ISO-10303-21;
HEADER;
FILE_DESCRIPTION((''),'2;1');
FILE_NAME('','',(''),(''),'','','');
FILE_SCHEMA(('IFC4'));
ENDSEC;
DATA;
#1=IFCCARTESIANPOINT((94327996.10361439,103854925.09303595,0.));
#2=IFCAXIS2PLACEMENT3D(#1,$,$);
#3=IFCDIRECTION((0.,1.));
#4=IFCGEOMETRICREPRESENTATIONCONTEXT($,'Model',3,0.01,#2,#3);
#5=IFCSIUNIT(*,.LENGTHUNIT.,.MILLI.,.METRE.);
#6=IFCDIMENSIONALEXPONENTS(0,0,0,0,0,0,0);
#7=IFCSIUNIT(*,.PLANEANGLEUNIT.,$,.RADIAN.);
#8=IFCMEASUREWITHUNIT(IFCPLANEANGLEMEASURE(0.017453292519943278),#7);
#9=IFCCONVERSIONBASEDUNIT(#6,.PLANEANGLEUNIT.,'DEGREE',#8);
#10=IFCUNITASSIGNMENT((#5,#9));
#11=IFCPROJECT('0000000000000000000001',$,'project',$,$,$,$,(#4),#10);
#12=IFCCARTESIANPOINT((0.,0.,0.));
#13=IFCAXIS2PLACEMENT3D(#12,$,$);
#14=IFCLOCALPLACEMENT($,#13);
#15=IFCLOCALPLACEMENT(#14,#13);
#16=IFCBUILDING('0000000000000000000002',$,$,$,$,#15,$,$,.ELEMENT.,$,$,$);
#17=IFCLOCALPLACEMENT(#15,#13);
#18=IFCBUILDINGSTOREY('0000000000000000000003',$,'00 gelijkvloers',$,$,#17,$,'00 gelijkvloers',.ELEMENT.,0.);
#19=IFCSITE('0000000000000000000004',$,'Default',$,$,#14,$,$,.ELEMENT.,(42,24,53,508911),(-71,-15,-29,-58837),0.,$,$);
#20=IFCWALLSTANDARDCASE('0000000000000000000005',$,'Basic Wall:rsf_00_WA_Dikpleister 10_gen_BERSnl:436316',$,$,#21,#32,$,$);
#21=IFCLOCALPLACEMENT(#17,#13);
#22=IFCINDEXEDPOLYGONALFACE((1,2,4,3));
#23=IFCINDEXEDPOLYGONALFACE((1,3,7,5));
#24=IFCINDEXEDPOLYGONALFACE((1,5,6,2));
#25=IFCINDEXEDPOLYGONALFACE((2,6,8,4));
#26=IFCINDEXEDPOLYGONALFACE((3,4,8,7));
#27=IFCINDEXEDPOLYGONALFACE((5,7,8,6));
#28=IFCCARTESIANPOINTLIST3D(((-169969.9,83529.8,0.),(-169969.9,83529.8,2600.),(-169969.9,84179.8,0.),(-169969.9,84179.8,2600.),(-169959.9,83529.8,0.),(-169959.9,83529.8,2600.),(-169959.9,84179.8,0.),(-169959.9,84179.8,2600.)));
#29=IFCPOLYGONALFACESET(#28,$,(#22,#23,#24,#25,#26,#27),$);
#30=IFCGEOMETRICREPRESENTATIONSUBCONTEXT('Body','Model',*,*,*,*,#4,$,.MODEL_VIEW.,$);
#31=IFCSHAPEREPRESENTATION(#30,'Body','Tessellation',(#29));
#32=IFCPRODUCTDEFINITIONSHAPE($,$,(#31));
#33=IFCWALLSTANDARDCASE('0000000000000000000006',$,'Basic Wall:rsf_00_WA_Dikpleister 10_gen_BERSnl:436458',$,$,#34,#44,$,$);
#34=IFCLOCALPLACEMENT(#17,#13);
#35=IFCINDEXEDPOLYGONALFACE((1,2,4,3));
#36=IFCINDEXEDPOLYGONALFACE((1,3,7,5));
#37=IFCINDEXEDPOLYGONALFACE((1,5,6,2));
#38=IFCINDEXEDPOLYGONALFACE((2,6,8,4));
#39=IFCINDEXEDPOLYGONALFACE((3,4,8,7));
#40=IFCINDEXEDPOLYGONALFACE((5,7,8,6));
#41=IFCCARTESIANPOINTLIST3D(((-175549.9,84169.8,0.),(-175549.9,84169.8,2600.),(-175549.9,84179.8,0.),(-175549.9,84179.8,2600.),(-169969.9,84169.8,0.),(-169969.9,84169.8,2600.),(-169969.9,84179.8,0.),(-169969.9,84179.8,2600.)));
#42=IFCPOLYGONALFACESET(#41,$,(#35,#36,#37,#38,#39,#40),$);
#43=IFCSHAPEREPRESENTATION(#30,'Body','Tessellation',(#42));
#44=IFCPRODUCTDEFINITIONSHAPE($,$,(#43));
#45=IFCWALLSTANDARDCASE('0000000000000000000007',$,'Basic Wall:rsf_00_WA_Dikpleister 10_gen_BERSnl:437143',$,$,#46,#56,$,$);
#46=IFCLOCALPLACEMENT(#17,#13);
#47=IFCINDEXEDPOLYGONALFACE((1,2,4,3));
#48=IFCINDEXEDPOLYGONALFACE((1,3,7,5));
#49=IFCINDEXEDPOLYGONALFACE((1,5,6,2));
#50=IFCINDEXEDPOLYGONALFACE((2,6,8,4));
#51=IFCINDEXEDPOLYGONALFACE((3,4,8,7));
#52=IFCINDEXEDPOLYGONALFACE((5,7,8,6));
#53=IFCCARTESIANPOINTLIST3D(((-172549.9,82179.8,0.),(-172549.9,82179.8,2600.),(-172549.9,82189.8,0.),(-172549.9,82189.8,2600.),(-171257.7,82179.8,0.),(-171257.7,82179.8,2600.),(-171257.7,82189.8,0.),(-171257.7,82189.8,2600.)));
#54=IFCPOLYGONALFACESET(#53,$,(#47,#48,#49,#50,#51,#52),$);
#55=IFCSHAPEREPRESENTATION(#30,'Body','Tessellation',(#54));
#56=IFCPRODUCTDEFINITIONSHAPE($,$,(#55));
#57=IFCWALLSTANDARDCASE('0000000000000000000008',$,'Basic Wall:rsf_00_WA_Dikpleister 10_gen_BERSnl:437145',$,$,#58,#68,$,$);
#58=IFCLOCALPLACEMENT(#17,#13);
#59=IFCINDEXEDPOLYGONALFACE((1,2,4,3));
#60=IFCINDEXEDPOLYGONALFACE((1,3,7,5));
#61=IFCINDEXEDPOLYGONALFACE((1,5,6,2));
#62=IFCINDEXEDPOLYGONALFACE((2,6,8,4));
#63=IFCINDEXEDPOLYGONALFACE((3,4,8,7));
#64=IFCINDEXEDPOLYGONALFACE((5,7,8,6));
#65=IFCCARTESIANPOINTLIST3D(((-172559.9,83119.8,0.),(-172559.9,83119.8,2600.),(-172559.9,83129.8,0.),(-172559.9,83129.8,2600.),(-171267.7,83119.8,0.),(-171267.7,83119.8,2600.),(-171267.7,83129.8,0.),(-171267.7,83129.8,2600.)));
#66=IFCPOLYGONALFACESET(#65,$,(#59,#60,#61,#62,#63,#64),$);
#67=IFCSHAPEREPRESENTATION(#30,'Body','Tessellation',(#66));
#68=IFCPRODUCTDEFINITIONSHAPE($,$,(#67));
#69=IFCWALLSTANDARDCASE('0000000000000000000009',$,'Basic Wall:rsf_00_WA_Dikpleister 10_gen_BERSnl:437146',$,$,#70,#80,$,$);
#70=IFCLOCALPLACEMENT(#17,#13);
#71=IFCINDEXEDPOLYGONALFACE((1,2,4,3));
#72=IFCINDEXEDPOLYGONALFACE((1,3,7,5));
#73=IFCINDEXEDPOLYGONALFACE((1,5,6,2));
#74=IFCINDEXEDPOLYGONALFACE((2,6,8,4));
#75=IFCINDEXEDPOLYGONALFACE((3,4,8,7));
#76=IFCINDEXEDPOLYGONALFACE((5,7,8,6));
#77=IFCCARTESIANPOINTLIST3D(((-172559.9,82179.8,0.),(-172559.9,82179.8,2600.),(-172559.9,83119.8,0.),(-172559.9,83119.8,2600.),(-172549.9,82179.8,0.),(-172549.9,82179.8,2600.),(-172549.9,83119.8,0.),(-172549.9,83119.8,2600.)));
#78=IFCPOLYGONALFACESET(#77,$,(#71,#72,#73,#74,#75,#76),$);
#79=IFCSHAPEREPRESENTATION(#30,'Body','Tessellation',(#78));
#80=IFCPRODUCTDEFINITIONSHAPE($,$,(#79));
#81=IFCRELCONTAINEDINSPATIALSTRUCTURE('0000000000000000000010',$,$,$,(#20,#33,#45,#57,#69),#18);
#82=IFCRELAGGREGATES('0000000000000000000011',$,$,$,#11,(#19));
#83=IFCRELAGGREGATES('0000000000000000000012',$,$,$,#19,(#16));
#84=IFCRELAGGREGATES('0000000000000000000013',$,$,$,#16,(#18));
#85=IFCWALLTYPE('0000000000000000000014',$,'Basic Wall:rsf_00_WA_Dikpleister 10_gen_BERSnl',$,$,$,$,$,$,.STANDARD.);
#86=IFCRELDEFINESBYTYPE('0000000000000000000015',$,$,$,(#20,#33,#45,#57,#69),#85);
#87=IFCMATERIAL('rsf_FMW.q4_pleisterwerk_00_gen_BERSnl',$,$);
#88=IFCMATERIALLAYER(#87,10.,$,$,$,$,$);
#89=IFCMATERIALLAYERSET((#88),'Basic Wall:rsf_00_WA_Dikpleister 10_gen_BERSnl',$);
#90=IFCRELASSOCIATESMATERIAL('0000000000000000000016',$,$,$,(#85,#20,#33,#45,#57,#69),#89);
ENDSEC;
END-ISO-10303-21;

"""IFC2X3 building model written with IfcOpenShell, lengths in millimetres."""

from ifc_helpers import new_model, entity, si_unit, converted_unit, direction, frame, frame_2d, origin, place, context, subcontext, project, spatial, rectangle, extrude, material, layer, layer_set, layer_usage, type_object, element, save


model = new_model("IFC2X3")

# Units and contexts
model_context = context("Model", 3, precision=0.01, world=frame((94327996.10361439, 103854925.09303595, 0.0)), true_north=direction((0.0, 1.0)))
body_context = subcontext(model_context, "Body", "Model", "MODEL_VIEW")
ifc_project = project(units=[si_unit("LENGTHUNIT", "METRE", prefix="MILLI"), converted_unit("PLANEANGLEUNIT", "DEGREE", entity("IfcPlaneAngleMeasure", 0.017453292519943278), si_unit("PLANEANGLEUNIT", "RADIAN"), dimensions=[0, 0, 0, 0, 0, 0, 0])], contexts=[model_context])

# Site, building, storey
site_placement = place(None, origin())
site = spatial("IfcSite", under=ifc_project, at=site_placement, Name="Default", CompositionType="ELEMENT", RefLatitude=(42, 24, 53, 508911), RefLongitude=(-71, -15, -29, -58837), RefElevation=0.0)
building_placement = place(site_placement, origin())
building = spatial("IfcBuilding", under=site, at=building_placement, CompositionType="ELEMENT")
storey_placement = place(building_placement, origin())
storey = spatial("IfcBuildingStorey", under=building, at=storey_placement, Name="00 gelijkvloers", LongName="00 gelijkvloers", CompositionType="ELEMENT", Elevation=0.0)

# Shared definitions
ifc_material_1 = material(Name="rsf_FMW.q4_pleisterwerk_00_gen_BERSnl")

# Walls
ifc_layer_1 = layer(ifc_material_1, 10.0)
ifc_layer_set_1 = layer_set([ifc_layer_1], Name="Basic Wall:rsf_00_WA_Dikpleister 10_gen_BERSnl")
wall_type_1 = type_object("IfcWallType", Name="Basic Wall:rsf_00_WA_Dikpleister 10_gen_BERSnl", PredefinedType="STANDARD", material=ifc_layer_set_1)
ifc_layer_usage_1 = layer_usage(ifc_layer_set_1, "AXIS2", "NEGATIVE", 5.0)
wall_1_placement = place(storey_placement, frame((-169964.9, 83529.8, 0.0), z_axis=(0.0, 0.0, 1.0), x_axis=(0.0, 1.0, 0.0)))
element("IfcWallStandardCase", 1, at=wall_1_placement, inside=storey, type_object=wall_type_1, material=ifc_layer_usage_1, Name="Basic Wall:rsf_00_WA_Dikpleister 10_gen_BERSnl:436316", context=body_context, shape_type="SweptSolid", body=[
    extrude(rectangle(XDim=650.0, YDim=10.0, at=frame_2d((325.0, 0.0), x_axis=(-1.0, 0.0))), origin(), (0.0, 0.0, 1.0), 2600.0),
])
ifc_layer_usage_2 = layer_usage(ifc_layer_set_1, "AXIS2", "NEGATIVE", 5.0)
wall_2_placement = place(storey_placement, frame((-169969.9, 84174.8, 0.0), z_axis=(0.0, 0.0, 1.0), x_axis=(-1.0, 0.0, 0.0)))
element("IfcWallStandardCase", 2, at=wall_2_placement, inside=storey, type_object=wall_type_1, material=ifc_layer_usage_2, Name="Basic Wall:rsf_00_WA_Dikpleister 10_gen_BERSnl:436458", context=body_context, shape_type="SweptSolid", body=[
    extrude(rectangle(XDim=5580.0, YDim=10.0, at=frame_2d((2790.0, 0.0), x_axis=(-1.0, 0.0))), origin(), (0.0, 0.0, 1.0), 2600.0),
])

# Wall
ifc_layer_usage_3 = layer_usage(ifc_layer_set_1, "AXIS2", "POSITIVE", -5.0)
wall_3_placement = place(storey_placement, frame((-171257.7, 82184.8, 0.0), z_axis=(0.0, 0.0, 1.0), x_axis=(-1.0, 0.0, 0.0)))
element("IfcWallStandardCase", 3, at=wall_3_placement, inside=storey, type_object=wall_type_1, material=ifc_layer_usage_3, Name="Basic Wall:rsf_00_WA_Dikpleister 10_gen_BERSnl:437143", context=body_context, shape_type="SweptSolid", body=[
    extrude(rectangle(XDim=1292.2, YDim=10.0, at=frame_2d((646.1, 0.0), x_axis=(-1.0, 0.0))), origin(), (0.0, 0.0, 1.0), 2600.0),
])

# Walls
ifc_layer_usage_4 = layer_usage(ifc_layer_set_1, "AXIS2", "POSITIVE", -5.0)
wall_4_placement = place(storey_placement, frame((-172559.9, 83124.8, 0.0)))
element("IfcWallStandardCase", 4, at=wall_4_placement, inside=storey, type_object=wall_type_1, material=ifc_layer_usage_4, Name="Basic Wall:rsf_00_WA_Dikpleister 10_gen_BERSnl:437145", context=body_context, shape_type="SweptSolid", body=[
    extrude(rectangle(XDim=1292.2, YDim=10.0, at=frame_2d((646.1, 0.0), x_axis=(-1.0, 0.0))), origin(), (0.0, 0.0, 1.0), 2600.0),
])
ifc_layer_usage_5 = layer_usage(ifc_layer_set_1, "AXIS2", "POSITIVE", -5.0)
wall_5_placement = place(storey_placement, frame((-172554.9, 82179.8, 0.0), z_axis=(0.0, 0.0, 1.0), x_axis=(0.0, 1.0, 0.0)))
element("IfcWallStandardCase", 5, at=wall_5_placement, inside=storey, type_object=wall_type_1, material=ifc_layer_usage_5, Name="Basic Wall:rsf_00_WA_Dikpleister 10_gen_BERSnl:437146", context=body_context, shape_type="SweptSolid", body=[
    extrude(rectangle(XDim=940.0, YDim=10.0, at=frame_2d((470.0, 0.0), x_axis=(-1.0, 0.0))), origin(), (0.0, 0.0, 1.0), 2600.0),
])

save(model, "model.ifc")
